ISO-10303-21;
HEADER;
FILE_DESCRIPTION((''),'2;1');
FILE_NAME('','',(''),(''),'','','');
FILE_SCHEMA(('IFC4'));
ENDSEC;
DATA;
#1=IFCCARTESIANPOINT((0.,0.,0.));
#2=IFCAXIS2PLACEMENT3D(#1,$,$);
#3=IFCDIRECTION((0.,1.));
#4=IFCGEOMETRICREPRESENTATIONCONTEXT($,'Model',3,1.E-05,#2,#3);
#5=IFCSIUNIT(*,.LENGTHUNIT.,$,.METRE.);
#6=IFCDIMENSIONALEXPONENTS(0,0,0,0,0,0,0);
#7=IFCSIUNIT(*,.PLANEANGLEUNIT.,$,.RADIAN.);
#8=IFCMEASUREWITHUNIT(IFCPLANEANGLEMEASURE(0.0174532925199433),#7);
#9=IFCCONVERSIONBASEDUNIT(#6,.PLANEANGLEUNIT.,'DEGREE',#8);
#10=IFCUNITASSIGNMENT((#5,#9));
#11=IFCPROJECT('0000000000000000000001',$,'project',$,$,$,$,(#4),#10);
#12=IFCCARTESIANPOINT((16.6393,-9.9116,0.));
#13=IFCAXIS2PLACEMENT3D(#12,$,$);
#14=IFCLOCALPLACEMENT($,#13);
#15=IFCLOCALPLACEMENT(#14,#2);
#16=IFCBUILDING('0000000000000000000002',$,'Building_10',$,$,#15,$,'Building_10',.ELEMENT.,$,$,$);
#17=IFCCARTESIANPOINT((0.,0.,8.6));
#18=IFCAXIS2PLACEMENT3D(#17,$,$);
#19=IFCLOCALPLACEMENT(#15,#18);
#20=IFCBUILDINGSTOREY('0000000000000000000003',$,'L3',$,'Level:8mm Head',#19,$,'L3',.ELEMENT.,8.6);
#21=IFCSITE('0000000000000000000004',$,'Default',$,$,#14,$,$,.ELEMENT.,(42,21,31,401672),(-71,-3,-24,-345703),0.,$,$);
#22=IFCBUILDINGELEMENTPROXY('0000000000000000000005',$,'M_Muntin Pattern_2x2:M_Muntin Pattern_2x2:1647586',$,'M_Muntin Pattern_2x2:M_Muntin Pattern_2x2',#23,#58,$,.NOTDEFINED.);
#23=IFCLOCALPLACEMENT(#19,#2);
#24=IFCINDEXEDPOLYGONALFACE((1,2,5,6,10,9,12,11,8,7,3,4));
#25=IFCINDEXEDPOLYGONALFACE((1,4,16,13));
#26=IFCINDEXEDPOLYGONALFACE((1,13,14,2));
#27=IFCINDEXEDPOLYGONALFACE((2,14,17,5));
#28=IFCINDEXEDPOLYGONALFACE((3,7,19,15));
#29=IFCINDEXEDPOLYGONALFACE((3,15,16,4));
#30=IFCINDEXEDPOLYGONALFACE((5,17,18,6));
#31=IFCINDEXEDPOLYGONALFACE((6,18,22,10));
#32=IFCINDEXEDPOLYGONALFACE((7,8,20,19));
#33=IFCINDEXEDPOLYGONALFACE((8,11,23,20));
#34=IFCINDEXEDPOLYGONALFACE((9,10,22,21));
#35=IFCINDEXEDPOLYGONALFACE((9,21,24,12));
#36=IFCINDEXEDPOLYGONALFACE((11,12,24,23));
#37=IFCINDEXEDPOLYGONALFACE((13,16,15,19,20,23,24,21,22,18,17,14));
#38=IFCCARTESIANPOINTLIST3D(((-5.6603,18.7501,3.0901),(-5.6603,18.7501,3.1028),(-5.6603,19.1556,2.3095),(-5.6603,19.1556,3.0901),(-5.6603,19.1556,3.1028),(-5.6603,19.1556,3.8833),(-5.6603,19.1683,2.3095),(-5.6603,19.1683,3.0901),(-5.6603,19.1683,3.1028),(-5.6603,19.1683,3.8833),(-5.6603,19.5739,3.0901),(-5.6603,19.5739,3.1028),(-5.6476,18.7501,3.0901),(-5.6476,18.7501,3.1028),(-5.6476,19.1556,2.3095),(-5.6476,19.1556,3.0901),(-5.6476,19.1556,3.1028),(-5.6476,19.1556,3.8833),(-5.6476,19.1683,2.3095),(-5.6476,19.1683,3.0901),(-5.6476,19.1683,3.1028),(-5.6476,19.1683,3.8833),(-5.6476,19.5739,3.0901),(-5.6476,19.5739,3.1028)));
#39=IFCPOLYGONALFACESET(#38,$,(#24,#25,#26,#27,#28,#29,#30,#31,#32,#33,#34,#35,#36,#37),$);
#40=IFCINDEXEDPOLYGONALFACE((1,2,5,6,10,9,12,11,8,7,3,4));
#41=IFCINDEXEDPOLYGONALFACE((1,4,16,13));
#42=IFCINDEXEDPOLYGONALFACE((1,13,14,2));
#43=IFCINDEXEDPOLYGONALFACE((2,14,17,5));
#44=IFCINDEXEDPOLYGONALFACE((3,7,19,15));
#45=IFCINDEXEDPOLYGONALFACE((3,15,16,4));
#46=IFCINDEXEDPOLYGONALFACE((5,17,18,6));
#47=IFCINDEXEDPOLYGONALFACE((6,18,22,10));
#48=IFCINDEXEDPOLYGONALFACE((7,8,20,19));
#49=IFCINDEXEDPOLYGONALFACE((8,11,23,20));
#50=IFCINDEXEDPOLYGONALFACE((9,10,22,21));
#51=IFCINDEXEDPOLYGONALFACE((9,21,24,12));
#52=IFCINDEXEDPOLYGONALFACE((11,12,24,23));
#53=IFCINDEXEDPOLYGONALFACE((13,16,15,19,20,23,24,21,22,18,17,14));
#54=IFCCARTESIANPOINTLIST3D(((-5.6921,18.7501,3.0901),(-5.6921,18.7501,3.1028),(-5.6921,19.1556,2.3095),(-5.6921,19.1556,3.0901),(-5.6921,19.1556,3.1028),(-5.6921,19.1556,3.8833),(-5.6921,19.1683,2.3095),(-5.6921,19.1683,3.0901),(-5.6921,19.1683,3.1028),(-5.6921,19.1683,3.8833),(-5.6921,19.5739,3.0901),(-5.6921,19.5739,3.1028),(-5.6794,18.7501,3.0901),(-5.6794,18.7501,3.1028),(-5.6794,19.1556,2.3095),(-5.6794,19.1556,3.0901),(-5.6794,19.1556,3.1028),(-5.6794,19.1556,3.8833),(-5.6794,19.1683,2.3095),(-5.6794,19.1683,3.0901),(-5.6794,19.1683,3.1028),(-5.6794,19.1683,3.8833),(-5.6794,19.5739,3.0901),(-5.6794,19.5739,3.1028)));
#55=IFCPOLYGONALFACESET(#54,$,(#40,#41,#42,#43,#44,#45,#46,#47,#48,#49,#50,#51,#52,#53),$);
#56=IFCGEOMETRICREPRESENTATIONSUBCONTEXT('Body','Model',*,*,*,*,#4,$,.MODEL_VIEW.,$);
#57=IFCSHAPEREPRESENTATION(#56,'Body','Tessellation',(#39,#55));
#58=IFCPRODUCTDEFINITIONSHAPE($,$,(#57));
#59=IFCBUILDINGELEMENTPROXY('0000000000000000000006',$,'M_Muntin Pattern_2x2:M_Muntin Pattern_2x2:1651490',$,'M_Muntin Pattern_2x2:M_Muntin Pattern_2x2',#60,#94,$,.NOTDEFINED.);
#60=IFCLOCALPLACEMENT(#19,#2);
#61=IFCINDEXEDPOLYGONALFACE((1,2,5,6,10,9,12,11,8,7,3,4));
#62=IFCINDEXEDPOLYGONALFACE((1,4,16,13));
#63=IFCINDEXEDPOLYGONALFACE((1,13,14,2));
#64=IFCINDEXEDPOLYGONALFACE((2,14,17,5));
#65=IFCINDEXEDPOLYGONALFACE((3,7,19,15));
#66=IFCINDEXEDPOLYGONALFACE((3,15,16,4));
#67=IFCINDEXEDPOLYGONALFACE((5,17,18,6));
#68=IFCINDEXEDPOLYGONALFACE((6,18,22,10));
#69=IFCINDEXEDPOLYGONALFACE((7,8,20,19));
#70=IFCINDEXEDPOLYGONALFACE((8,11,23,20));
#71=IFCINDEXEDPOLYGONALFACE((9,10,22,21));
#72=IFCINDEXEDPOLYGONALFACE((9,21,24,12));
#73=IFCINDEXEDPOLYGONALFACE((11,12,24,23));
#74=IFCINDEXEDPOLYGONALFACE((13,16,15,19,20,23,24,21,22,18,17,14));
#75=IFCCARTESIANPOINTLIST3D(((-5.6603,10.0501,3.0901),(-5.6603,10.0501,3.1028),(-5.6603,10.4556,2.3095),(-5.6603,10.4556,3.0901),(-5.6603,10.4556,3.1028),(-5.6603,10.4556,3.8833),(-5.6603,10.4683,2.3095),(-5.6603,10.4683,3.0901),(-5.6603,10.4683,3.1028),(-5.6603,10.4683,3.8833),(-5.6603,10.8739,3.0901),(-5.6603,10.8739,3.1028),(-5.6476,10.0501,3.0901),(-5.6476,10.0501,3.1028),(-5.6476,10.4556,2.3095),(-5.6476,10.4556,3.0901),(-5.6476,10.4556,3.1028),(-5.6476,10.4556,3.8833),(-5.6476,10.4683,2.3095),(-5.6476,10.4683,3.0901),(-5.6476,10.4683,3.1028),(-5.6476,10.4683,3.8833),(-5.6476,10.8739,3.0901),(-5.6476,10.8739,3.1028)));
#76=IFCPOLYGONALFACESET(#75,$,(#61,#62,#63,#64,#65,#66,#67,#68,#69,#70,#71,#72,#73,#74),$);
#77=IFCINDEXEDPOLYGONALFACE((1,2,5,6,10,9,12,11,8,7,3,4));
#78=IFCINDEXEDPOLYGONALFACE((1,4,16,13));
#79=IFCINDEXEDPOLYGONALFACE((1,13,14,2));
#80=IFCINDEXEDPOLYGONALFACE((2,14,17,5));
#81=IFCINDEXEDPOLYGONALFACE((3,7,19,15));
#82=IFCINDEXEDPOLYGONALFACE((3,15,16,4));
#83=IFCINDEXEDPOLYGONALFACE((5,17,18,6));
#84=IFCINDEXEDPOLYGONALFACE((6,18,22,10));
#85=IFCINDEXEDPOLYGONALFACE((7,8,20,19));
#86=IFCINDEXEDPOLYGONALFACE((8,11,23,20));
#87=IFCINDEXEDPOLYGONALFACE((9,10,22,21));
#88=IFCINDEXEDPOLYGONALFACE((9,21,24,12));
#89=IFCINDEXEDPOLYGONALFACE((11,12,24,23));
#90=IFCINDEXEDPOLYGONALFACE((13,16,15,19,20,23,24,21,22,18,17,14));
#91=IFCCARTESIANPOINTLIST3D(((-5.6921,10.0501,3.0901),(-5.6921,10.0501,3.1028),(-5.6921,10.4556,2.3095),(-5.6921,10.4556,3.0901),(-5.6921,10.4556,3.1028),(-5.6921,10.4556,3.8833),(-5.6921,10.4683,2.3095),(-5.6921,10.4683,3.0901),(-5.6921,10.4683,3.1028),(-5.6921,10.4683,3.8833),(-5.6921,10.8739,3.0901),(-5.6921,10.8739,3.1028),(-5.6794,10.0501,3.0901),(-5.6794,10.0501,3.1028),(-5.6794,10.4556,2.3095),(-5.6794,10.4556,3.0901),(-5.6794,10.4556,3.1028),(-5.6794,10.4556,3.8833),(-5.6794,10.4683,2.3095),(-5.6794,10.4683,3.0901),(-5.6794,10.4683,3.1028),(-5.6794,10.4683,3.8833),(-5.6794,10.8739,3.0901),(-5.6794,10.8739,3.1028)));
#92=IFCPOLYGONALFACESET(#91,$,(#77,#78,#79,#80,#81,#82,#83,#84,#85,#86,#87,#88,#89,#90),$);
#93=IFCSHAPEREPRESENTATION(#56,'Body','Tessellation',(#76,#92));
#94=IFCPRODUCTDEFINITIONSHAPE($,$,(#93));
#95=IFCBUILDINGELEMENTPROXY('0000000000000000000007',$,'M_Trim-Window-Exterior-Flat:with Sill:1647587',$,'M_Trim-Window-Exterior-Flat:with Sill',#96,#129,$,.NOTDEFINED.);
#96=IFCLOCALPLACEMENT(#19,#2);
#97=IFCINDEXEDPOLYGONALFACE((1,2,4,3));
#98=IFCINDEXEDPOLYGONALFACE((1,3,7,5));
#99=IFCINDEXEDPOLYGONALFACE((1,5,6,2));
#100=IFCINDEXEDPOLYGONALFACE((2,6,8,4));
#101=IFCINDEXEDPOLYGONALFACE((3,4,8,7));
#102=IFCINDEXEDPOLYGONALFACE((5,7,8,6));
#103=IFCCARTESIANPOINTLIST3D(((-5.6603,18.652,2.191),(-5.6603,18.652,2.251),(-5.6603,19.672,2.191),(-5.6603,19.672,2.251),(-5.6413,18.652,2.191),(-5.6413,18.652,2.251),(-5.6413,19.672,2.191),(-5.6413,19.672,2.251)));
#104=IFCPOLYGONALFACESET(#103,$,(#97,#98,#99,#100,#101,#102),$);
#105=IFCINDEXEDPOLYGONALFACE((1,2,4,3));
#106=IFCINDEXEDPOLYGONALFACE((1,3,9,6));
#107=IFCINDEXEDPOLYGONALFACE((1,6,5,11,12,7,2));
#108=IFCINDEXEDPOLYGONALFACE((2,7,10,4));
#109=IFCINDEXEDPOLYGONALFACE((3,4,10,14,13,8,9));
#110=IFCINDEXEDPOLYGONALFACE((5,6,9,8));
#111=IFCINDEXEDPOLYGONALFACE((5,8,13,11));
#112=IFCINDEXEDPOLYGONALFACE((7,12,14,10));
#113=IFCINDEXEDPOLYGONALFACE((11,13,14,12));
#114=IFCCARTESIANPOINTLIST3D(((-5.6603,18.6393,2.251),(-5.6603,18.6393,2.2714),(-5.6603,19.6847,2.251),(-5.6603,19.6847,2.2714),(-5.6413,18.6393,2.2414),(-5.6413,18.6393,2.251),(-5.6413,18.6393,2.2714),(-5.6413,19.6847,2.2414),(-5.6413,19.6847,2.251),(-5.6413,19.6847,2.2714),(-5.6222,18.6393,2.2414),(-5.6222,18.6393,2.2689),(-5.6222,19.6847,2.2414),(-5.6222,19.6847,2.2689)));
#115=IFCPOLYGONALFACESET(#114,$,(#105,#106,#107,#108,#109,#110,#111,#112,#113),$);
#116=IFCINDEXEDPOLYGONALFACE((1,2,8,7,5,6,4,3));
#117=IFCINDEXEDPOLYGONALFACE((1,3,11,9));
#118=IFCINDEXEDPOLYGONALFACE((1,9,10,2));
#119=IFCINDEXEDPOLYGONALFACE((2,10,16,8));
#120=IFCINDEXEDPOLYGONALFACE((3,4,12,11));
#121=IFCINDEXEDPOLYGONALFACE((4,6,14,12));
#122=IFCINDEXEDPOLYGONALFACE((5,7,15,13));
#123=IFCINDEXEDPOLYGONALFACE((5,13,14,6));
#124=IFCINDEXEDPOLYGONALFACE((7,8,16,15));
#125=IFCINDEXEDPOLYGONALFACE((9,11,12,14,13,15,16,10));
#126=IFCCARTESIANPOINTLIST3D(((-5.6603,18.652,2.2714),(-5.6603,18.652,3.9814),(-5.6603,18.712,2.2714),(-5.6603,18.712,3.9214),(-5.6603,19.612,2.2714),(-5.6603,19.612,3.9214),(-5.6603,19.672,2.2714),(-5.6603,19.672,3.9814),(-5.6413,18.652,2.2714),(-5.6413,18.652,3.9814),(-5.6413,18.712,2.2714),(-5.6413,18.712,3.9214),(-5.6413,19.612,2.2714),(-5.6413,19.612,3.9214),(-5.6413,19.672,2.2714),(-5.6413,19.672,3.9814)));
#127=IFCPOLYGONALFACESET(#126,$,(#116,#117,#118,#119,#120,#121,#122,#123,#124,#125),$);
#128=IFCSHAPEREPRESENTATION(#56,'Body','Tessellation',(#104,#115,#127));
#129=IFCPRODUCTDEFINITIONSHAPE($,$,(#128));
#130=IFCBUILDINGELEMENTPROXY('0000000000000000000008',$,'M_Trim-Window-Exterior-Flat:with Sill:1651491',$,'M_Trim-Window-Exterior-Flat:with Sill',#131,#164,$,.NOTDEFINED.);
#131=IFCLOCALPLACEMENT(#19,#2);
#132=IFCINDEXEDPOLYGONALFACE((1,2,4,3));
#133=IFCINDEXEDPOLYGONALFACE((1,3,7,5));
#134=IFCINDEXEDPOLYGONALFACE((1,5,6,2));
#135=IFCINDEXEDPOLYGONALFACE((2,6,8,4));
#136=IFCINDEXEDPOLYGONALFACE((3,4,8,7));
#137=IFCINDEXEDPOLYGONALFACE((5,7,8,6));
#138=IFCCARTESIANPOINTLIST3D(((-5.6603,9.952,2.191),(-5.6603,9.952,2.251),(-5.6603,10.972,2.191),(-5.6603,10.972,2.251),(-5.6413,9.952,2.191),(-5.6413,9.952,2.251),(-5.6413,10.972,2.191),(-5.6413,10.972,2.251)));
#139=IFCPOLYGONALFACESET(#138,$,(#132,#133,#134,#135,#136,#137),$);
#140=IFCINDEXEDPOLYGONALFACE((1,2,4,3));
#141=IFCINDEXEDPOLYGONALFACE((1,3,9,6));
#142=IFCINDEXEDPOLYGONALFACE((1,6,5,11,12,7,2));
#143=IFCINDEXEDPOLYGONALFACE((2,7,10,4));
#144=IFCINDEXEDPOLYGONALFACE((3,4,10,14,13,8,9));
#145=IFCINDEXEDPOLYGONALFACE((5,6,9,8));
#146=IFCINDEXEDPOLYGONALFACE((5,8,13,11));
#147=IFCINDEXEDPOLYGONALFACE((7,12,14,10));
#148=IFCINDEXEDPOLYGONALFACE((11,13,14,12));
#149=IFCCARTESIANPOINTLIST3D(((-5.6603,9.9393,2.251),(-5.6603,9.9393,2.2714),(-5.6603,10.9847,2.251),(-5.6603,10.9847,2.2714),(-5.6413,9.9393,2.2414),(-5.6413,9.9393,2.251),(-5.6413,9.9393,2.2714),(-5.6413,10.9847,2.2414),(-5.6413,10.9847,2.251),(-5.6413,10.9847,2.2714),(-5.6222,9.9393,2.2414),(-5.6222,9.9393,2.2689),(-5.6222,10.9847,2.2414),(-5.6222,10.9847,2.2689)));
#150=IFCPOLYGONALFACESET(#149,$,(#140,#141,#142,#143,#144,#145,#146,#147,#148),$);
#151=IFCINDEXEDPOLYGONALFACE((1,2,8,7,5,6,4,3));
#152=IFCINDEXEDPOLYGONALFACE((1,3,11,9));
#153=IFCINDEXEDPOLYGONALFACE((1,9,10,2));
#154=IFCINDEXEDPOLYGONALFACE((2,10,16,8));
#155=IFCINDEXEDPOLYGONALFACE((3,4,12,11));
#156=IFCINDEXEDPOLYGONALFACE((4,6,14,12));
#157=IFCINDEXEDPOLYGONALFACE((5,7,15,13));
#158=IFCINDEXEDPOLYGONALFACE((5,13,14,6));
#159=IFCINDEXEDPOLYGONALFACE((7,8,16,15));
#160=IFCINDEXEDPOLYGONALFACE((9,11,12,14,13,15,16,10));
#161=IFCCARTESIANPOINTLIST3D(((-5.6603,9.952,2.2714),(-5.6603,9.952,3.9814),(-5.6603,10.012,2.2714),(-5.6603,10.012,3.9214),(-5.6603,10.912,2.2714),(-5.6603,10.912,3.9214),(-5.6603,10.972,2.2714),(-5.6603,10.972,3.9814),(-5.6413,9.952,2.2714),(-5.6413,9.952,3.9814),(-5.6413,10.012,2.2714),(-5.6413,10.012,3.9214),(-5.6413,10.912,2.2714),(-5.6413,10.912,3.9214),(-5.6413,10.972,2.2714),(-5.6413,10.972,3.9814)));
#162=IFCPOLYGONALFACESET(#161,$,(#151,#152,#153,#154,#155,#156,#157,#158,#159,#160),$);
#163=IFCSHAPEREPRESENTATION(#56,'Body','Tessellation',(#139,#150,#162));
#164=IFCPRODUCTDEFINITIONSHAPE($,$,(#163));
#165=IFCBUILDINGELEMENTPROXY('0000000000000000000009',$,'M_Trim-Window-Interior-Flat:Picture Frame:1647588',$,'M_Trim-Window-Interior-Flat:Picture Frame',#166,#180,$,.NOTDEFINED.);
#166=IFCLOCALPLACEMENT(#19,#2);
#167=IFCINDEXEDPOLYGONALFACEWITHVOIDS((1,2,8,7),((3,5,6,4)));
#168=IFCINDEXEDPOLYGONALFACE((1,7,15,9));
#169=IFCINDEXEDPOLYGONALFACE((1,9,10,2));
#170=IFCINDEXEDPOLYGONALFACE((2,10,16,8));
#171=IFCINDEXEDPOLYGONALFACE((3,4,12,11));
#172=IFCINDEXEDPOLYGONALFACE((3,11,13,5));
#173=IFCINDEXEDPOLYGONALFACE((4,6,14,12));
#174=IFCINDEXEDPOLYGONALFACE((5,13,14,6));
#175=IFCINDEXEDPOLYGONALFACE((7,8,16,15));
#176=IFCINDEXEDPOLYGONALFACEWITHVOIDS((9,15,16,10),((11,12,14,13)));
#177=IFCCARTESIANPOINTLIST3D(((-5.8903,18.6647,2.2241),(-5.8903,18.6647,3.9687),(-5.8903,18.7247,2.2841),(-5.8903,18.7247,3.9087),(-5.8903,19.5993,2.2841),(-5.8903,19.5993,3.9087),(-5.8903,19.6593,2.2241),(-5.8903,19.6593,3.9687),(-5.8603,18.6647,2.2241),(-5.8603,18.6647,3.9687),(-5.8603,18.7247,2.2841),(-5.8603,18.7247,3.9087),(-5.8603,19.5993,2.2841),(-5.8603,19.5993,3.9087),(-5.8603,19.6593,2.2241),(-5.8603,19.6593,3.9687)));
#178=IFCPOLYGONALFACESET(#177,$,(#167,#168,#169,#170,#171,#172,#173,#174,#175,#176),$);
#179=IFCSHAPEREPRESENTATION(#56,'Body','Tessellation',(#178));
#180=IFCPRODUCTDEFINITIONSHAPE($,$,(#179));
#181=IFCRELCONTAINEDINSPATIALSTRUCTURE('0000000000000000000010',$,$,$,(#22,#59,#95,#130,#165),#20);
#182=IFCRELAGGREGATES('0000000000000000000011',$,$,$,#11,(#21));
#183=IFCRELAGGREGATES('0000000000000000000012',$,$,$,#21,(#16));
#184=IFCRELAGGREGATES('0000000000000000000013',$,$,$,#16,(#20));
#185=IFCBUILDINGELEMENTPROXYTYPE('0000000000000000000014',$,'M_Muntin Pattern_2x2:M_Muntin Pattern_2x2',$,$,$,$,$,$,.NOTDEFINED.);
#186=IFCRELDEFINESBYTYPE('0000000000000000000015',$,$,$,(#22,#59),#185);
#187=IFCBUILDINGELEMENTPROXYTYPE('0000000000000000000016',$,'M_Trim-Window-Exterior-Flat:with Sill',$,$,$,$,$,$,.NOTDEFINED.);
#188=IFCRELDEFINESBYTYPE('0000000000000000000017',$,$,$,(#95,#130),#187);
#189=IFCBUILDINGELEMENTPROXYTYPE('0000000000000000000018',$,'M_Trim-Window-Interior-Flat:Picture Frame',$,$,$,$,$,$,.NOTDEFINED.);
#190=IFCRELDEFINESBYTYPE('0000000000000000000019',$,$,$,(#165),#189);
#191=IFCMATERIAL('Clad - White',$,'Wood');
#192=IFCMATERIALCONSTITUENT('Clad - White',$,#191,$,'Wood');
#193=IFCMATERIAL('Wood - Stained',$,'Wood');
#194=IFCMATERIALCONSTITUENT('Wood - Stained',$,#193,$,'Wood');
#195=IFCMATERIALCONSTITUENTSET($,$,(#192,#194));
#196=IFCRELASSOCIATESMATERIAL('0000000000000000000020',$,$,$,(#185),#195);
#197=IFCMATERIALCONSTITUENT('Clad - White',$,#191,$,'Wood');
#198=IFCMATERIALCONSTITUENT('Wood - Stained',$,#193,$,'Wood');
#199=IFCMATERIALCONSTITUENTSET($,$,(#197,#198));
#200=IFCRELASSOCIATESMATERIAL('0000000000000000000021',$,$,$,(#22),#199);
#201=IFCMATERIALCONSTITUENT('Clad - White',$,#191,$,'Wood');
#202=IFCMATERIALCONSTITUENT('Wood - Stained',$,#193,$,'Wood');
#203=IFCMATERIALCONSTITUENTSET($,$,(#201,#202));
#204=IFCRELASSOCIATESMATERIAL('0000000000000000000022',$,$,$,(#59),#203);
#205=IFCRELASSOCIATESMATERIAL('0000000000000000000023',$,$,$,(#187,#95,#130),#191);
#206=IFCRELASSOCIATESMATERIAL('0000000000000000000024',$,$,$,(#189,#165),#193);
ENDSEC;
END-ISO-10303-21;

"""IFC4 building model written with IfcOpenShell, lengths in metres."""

from ifc_helpers import new_model, entity, si_unit, converted_unit, direction, frame, origin, place, context, subcontext, project, spatial, indexed_curve, outline, extrude, source, transform, mapped, material, constituent, constituent_set, type_object, type_shapes, element, save


model = new_model("IFC4")

# Units and contexts
model_context = context("Model", 3, precision=1e-05, world=origin(), true_north=direction((0.0, 1.0)))
body_context = subcontext(model_context, "Body", "Model", "MODEL_VIEW")
ifc_project = project(units=[si_unit("LENGTHUNIT", "METRE"), converted_unit("PLANEANGLEUNIT", "DEGREE", entity("IfcPlaneAngleMeasure", 0.0174532925199433), si_unit("PLANEANGLEUNIT", "RADIAN"), dimensions=[0, 0, 0, 0, 0, 0, 0])], contexts=[model_context])

# Site, building, storey
site_placement = place(None, frame((16.6393, -9.9116, 0.0)))
site = spatial("IfcSite", under=ifc_project, at=site_placement, Name="Default", CompositionType="ELEMENT", RefLatitude=(42, 21, 31, 401672), RefLongitude=(-71, -3, -24, -345703), RefElevation=0.0)
building_placement = place(site_placement, origin())
building = spatial("IfcBuilding", under=site, at=building_placement, Name="Building_10", LongName="Building_10", CompositionType="ELEMENT")
storey_placement = place(building_placement, frame((0.0, 0.0, 8.6)))
storey = spatial("IfcBuildingStorey", under=building, at=storey_placement, Name="L3", ObjectType="Level:8mm Head", LongName="L3", CompositionType="ELEMENT", Elevation=8.6)

# Building element proxies
ifc_material_1 = material(Name="Clad - White", Category="Wood")
ifc_constituent_1 = constituent(ifc_material_1, Name="Clad - White", Category="Wood")
ifc_material_2 = material(Name="Wood - Stained", Category="Wood")
ifc_constituent_2 = constituent(ifc_material_2, Name="Wood - Stained", Category="Wood")
ifc_constituent_set_1 = constituent_set(constituents=[ifc_constituent_1, ifc_constituent_2])
ifc_constituent_3 = constituent(ifc_material_1, Name="Clad - White", Category="Wood")
ifc_constituent_4 = constituent(ifc_material_2, Name="Wood - Stained", Category="Wood")
ifc_constituent_set_2 = constituent_set(constituents=[ifc_constituent_3, ifc_constituent_4])
building_element_proxy_type_1 = type_object("IfcBuildingElementProxyType", Name="M_Muntin Pattern_2x2:M_Muntin Pattern_2x2", PredefinedType="NOTDEFINED", material=ifc_constituent_set_2)
shared_shape_1 = source(origin(), body_context, "Body", "SweptSolid", [
    extrude(outline(indexed_curve([(0.0064, -0.0064), (0.7869, -0.0064), (0.7869, 0.0063), (0.0064, 0.0063), (0.0064, 0.4119), (-0.0063, 0.4119), (-0.0063, 0.0063), (-0.7869, 0.0063), (-0.7869, -0.0064), (-0.0063, -0.0064), (-0.0063, -0.4119), (0.0064, -0.4119), (0.0064, -0.0064)], self_intersect=False)), frame((0.0, -0.0222, 0.7869), z_axis=(0.0, 1.0, 0.0), x_axis=(0.0, 0.0, 1.0)), (0.0, 0.0, 1.0), 0.0127),
    extrude(outline(indexed_curve([(0.0064, -0.0064), (0.7869, -0.0064), (0.7869, 0.0063), (0.0064, 0.0063), (0.0064, 0.4119), (-0.0063, 0.4119), (-0.0063, 0.0063), (-0.7869, 0.0063), (-0.7869, -0.0064), (-0.0063, -0.0064), (-0.0063, -0.4119), (0.0064, -0.4119), (0.0064, -0.0064)], self_intersect=False)), frame((0.0, 0.0095, 0.7869), z_axis=(0.0, 1.0, 0.0), x_axis=(0.0, 0.0, 1.0)), (0.0, 0.0, 1.0), 0.0127),
])
type_shapes(building_element_proxy_type_1, [shared_shape_1])
proxy_1_placement = place(storey_placement, frame((-5.6698, 19.162, 2.3095), z_axis=(0.0, 0.0, 1.0), x_axis=(0.0, 1.0, 0.0)))
element("IfcBuildingElementProxy", 1, at=proxy_1_placement, inside=storey, type_object=building_element_proxy_type_1, material=ifc_constituent_set_1, Name="M_Muntin Pattern_2x2:M_Muntin Pattern_2x2:1647586", ObjectType="M_Muntin Pattern_2x2:M_Muntin Pattern_2x2", PredefinedType="NOTDEFINED", context=body_context, shape_type="MappedRepresentation", body=[
    mapped(shared_shape_1, transform((0.0, 0.0, 0.0), scale=1.0)),
])
ifc_constituent_5 = constituent(ifc_material_1, Name="Clad - White", Category="Wood")
ifc_constituent_6 = constituent(ifc_material_2, Name="Wood - Stained", Category="Wood")
ifc_constituent_set_3 = constituent_set(constituents=[ifc_constituent_5, ifc_constituent_6])
proxy_2_placement = place(storey_placement, frame((-5.6698, 10.462, 2.3095), z_axis=(0.0, 0.0, 1.0), x_axis=(0.0, 1.0, 0.0)))
element("IfcBuildingElementProxy", 2, at=proxy_2_placement, inside=storey, type_object=building_element_proxy_type_1, material=ifc_constituent_set_3, Name="M_Muntin Pattern_2x2:M_Muntin Pattern_2x2:1651490", ObjectType="M_Muntin Pattern_2x2:M_Muntin Pattern_2x2", PredefinedType="NOTDEFINED", context=body_context, shape_type="MappedRepresentation", body=[
    mapped(shared_shape_1, transform((0.0, 0.0, 0.0), scale=1.0)),
])
building_element_proxy_type_2 = type_object("IfcBuildingElementProxyType", Name="M_Trim-Window-Exterior-Flat:with Sill", PredefinedType="NOTDEFINED", material=ifc_material_1)
shared_shape_2 = source(origin(), body_context, "Body", "SweptSolid", [
    extrude(outline(indexed_curve([(-0.51, -0.03), (0.51, -0.03), (0.51, 0.03), (-0.51, 0.03), (-0.51, -0.03)], self_intersect=False)), frame((0.0, -1.7004, 0.0), z_axis=(0.0, 0.0, 1.0), x_axis=(-1.0, 0.0, 0.0)), (0.0, 0.0, 1.0), 0.0191),
    extrude(outline(indexed_curve([(-0.019, -0.0152), (0.0, -0.0152), (0.0, -0.0057), (0.019, -0.0057), (0.019, 0.0148), (0.0, 0.0148), (-0.019, 0.0123), (-0.019, -0.0152)], self_intersect=False)), frame((-0.5227, -1.6648, 0.019), z_axis=(1.0, 0.0, 0.0), x_axis=(0.0, 0.0, -1.0)), (0.0, 0.0, 1.0), 1.0454),
    extrude(outline(indexed_curve([(-0.87, -0.51), (0.84, -0.51), (0.84, -0.45), (-0.81, -0.45), (-0.81, 0.45), (0.84, 0.45), (0.84, 0.51), (-0.87, 0.51), (-0.87, -0.51)], self_intersect=False)), frame((0.0, -0.81, 0.0), z_axis=(0.0, 0.0, 1.0), x_axis=(0.0, -1.0, 0.0)), (0.0, 0.0, 1.0), 0.0191),
])
type_shapes(building_element_proxy_type_2, [shared_shape_2])
for number, where, z_axis, x_axis, name in (
    (3, (-5.6603, 19.162, 3.9214), (1.0, 0.0, 0.0), (0.0, 1.0, 0.0), "M_Trim-Window-Exterior-Flat:with Sill:1647587"),
    (4, (-5.6603, 10.462, 3.9214), (1.0, 0.0, 0.0), (0.0, 1.0, 0.0), "M_Trim-Window-Exterior-Flat:with Sill:1651491"),
):
    element("IfcBuildingElementProxy", number, at=place(storey_placement, frame(where, z_axis=z_axis, x_axis=x_axis)), inside=storey, type_object=building_element_proxy_type_2, material=ifc_material_1, Name=name, ObjectType="M_Trim-Window-Exterior-Flat:with Sill", PredefinedType="NOTDEFINED", context=body_context, shape_type="MappedRepresentation", body=[
        mapped(shared_shape_2, transform((0.0, 0.0, 0.0), scale=1.0)),
    ])
building_element_proxy_type_3 = type_object("IfcBuildingElementProxyType", Name="M_Trim-Window-Interior-Flat:Picture Frame", PredefinedType="NOTDEFINED", material=ifc_material_2)
shared_shape_3 = source(origin(), body_context, "Body", "SweptSolid", [
    extrude(outline(indexed_curve([(-0.4973, -0.8723), (0.4973, -0.8723), (0.4973, 0.8723), (-0.4973, 0.8723), (-0.4973, -0.8723)], self_intersect=False), holes=[indexed_curve([(-0.4373, -0.8123), (-0.4373, 0.8123), (0.4373, 0.8123), (0.4373, -0.8123), (-0.4373, -0.8123)], self_intersect=False)]), frame((0.0, -0.825, 0.0), z_axis=(0.0, 0.0, 1.0), x_axis=(-1.0, 0.0, 0.0)), (0.0, 0.0, 1.0), 0.03),
])
type_shapes(building_element_proxy_type_3, [shared_shape_3])
for number, where, z_axis, x_axis, name in (
    (5, (-5.8603, 19.162, 3.9214), (-1.0, 0.0, 0.0), (0.0, -1.0, 0.0), "M_Trim-Window-Interior-Flat:Picture Frame:1647588"),
):
    element("IfcBuildingElementProxy", number, at=place(storey_placement, frame(where, z_axis=z_axis, x_axis=x_axis)), inside=storey, type_object=building_element_proxy_type_3, material=ifc_material_2, Name=name, ObjectType="M_Trim-Window-Interior-Flat:Picture Frame", PredefinedType="NOTDEFINED", context=body_context, shape_type="MappedRepresentation", body=[
        mapped(shared_shape_3, transform((0.0, 0.0, 0.0), scale=1.0)),
    ])

save(model, "model.ifc")
